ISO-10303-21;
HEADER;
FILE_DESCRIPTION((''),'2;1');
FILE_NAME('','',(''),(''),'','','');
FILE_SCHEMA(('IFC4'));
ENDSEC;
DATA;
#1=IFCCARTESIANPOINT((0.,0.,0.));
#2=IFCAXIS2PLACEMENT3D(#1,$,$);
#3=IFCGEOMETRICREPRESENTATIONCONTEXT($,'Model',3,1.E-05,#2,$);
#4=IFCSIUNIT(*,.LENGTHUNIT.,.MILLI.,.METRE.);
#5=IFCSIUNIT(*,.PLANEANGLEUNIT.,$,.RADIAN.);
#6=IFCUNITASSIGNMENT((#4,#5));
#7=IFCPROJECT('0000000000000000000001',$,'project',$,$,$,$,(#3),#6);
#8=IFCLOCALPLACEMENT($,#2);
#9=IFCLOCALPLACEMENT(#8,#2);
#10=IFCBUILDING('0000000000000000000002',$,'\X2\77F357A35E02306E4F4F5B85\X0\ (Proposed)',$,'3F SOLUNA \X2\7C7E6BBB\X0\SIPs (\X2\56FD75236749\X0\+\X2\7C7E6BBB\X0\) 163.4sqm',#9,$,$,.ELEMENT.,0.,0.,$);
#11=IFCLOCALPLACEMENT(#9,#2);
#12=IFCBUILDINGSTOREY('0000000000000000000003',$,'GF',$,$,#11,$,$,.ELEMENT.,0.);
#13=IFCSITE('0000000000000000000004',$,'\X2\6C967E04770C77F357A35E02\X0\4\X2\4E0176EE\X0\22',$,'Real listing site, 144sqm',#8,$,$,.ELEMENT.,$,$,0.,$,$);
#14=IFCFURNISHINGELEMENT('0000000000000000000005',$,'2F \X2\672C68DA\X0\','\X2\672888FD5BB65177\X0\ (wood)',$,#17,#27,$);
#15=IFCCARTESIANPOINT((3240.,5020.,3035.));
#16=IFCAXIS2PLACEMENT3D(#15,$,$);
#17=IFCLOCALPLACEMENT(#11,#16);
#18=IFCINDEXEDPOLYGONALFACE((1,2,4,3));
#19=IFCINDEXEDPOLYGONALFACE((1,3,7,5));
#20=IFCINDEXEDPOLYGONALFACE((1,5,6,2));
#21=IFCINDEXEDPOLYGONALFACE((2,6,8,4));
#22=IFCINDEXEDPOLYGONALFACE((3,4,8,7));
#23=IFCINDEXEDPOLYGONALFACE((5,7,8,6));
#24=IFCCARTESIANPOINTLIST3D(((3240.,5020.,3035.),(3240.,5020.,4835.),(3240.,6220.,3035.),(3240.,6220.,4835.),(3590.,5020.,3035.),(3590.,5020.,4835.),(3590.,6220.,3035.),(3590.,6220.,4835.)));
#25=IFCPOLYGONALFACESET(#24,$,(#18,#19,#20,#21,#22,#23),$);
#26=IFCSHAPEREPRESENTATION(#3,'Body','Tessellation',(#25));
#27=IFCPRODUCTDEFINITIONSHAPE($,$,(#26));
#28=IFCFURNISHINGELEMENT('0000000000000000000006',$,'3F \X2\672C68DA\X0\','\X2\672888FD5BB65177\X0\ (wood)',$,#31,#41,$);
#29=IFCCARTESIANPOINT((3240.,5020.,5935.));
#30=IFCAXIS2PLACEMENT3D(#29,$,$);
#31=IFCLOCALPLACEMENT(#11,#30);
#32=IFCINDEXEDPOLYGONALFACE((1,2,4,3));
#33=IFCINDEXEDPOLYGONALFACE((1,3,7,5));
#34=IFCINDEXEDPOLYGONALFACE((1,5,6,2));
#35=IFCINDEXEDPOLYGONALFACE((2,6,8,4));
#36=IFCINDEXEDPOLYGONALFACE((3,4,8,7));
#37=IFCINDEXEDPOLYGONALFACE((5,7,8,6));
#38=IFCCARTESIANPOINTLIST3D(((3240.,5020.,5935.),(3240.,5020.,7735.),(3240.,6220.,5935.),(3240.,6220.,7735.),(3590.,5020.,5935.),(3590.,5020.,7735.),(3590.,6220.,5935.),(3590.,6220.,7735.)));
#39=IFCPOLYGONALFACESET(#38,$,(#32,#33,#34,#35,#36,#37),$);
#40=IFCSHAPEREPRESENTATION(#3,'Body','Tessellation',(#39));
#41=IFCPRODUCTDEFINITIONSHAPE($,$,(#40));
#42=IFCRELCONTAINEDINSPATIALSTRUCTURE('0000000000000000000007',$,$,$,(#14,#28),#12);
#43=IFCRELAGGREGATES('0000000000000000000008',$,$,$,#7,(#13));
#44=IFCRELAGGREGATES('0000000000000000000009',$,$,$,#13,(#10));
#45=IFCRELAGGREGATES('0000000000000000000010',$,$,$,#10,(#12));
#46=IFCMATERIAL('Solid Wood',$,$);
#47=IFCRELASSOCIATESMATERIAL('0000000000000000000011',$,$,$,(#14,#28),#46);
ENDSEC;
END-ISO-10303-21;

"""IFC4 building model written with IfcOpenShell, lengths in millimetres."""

from ifc_helpers import new_model, si_unit, frame, frame_2d, origin, place, context, project, spatial, rectangle, extrude, material, element, save


model = new_model("IFC4")

# Units and contexts
model_context = context("Model", 3, precision=1e-05, world=origin())
ifc_project = project(units=[si_unit("LENGTHUNIT", "METRE", prefix="MILLI"), si_unit("PLANEANGLEUNIT", "RADIAN")], contexts=[model_context])

# Site, building, storey
site_placement = place(None, origin())
site = spatial("IfcSite", under=ifc_project, at=site_placement, Name="沖縄県石垣市4丁目22", ObjectType="Real listing site, 144sqm", CompositionType="ELEMENT", RefElevation=0.0)
building_placement = place(site_placement, origin())
building = spatial("IfcBuilding", under=site, at=building_placement, Name="石垣市の住宅 (Proposed)", ObjectType="3F SOLUNA 籾殻SIPs (国産杉+籾殻) 163.4sqm", CompositionType="ELEMENT", ElevationOfRefHeight=0.0, ElevationOfTerrain=0.0)
storey_placement = place(building_placement, origin())
storey = spatial("IfcBuildingStorey", under=building, at=storey_placement, Name="GF", CompositionType="ELEMENT", Elevation=0.0)

# Shared definitions
ifc_material_1 = material(Name="Solid Wood")

# Furnishing elements
furnishing_1_placement = place(storey_placement, frame((3240.0, 5020.0, 3035.0)))
element("IfcFurnishingElement", 1, at=furnishing_1_placement, inside=storey, material=ifc_material_1, Name="2F 本棚", Description="木製家具 (wood)", context=model_context, shape_type="SweptSolid", body=[
    extrude(rectangle(XDim=350.0, YDim=1200.0, at=frame_2d((175.0, 600.0))), frame((3240.0, 5020.0, 3035.0)), (0.0, 0.0, 1.0), 1800.0),
])
furnishing_2_placement = place(storey_placement, frame((3240.0, 5020.0, 5935.0)))
element("IfcFurnishingElement", 2, at=furnishing_2_placement, inside=storey, material=ifc_material_1, Name="3F 本棚", Description="木製家具 (wood)", context=model_context, shape_type="SweptSolid", body=[
    extrude(rectangle(XDim=350.0, YDim=1200.0, at=frame_2d((175.0, 600.0))), frame((3240.0, 5020.0, 5935.0)), (0.0, 0.0, 1.0), 1800.0),
])

save(model, "model.ifc")
